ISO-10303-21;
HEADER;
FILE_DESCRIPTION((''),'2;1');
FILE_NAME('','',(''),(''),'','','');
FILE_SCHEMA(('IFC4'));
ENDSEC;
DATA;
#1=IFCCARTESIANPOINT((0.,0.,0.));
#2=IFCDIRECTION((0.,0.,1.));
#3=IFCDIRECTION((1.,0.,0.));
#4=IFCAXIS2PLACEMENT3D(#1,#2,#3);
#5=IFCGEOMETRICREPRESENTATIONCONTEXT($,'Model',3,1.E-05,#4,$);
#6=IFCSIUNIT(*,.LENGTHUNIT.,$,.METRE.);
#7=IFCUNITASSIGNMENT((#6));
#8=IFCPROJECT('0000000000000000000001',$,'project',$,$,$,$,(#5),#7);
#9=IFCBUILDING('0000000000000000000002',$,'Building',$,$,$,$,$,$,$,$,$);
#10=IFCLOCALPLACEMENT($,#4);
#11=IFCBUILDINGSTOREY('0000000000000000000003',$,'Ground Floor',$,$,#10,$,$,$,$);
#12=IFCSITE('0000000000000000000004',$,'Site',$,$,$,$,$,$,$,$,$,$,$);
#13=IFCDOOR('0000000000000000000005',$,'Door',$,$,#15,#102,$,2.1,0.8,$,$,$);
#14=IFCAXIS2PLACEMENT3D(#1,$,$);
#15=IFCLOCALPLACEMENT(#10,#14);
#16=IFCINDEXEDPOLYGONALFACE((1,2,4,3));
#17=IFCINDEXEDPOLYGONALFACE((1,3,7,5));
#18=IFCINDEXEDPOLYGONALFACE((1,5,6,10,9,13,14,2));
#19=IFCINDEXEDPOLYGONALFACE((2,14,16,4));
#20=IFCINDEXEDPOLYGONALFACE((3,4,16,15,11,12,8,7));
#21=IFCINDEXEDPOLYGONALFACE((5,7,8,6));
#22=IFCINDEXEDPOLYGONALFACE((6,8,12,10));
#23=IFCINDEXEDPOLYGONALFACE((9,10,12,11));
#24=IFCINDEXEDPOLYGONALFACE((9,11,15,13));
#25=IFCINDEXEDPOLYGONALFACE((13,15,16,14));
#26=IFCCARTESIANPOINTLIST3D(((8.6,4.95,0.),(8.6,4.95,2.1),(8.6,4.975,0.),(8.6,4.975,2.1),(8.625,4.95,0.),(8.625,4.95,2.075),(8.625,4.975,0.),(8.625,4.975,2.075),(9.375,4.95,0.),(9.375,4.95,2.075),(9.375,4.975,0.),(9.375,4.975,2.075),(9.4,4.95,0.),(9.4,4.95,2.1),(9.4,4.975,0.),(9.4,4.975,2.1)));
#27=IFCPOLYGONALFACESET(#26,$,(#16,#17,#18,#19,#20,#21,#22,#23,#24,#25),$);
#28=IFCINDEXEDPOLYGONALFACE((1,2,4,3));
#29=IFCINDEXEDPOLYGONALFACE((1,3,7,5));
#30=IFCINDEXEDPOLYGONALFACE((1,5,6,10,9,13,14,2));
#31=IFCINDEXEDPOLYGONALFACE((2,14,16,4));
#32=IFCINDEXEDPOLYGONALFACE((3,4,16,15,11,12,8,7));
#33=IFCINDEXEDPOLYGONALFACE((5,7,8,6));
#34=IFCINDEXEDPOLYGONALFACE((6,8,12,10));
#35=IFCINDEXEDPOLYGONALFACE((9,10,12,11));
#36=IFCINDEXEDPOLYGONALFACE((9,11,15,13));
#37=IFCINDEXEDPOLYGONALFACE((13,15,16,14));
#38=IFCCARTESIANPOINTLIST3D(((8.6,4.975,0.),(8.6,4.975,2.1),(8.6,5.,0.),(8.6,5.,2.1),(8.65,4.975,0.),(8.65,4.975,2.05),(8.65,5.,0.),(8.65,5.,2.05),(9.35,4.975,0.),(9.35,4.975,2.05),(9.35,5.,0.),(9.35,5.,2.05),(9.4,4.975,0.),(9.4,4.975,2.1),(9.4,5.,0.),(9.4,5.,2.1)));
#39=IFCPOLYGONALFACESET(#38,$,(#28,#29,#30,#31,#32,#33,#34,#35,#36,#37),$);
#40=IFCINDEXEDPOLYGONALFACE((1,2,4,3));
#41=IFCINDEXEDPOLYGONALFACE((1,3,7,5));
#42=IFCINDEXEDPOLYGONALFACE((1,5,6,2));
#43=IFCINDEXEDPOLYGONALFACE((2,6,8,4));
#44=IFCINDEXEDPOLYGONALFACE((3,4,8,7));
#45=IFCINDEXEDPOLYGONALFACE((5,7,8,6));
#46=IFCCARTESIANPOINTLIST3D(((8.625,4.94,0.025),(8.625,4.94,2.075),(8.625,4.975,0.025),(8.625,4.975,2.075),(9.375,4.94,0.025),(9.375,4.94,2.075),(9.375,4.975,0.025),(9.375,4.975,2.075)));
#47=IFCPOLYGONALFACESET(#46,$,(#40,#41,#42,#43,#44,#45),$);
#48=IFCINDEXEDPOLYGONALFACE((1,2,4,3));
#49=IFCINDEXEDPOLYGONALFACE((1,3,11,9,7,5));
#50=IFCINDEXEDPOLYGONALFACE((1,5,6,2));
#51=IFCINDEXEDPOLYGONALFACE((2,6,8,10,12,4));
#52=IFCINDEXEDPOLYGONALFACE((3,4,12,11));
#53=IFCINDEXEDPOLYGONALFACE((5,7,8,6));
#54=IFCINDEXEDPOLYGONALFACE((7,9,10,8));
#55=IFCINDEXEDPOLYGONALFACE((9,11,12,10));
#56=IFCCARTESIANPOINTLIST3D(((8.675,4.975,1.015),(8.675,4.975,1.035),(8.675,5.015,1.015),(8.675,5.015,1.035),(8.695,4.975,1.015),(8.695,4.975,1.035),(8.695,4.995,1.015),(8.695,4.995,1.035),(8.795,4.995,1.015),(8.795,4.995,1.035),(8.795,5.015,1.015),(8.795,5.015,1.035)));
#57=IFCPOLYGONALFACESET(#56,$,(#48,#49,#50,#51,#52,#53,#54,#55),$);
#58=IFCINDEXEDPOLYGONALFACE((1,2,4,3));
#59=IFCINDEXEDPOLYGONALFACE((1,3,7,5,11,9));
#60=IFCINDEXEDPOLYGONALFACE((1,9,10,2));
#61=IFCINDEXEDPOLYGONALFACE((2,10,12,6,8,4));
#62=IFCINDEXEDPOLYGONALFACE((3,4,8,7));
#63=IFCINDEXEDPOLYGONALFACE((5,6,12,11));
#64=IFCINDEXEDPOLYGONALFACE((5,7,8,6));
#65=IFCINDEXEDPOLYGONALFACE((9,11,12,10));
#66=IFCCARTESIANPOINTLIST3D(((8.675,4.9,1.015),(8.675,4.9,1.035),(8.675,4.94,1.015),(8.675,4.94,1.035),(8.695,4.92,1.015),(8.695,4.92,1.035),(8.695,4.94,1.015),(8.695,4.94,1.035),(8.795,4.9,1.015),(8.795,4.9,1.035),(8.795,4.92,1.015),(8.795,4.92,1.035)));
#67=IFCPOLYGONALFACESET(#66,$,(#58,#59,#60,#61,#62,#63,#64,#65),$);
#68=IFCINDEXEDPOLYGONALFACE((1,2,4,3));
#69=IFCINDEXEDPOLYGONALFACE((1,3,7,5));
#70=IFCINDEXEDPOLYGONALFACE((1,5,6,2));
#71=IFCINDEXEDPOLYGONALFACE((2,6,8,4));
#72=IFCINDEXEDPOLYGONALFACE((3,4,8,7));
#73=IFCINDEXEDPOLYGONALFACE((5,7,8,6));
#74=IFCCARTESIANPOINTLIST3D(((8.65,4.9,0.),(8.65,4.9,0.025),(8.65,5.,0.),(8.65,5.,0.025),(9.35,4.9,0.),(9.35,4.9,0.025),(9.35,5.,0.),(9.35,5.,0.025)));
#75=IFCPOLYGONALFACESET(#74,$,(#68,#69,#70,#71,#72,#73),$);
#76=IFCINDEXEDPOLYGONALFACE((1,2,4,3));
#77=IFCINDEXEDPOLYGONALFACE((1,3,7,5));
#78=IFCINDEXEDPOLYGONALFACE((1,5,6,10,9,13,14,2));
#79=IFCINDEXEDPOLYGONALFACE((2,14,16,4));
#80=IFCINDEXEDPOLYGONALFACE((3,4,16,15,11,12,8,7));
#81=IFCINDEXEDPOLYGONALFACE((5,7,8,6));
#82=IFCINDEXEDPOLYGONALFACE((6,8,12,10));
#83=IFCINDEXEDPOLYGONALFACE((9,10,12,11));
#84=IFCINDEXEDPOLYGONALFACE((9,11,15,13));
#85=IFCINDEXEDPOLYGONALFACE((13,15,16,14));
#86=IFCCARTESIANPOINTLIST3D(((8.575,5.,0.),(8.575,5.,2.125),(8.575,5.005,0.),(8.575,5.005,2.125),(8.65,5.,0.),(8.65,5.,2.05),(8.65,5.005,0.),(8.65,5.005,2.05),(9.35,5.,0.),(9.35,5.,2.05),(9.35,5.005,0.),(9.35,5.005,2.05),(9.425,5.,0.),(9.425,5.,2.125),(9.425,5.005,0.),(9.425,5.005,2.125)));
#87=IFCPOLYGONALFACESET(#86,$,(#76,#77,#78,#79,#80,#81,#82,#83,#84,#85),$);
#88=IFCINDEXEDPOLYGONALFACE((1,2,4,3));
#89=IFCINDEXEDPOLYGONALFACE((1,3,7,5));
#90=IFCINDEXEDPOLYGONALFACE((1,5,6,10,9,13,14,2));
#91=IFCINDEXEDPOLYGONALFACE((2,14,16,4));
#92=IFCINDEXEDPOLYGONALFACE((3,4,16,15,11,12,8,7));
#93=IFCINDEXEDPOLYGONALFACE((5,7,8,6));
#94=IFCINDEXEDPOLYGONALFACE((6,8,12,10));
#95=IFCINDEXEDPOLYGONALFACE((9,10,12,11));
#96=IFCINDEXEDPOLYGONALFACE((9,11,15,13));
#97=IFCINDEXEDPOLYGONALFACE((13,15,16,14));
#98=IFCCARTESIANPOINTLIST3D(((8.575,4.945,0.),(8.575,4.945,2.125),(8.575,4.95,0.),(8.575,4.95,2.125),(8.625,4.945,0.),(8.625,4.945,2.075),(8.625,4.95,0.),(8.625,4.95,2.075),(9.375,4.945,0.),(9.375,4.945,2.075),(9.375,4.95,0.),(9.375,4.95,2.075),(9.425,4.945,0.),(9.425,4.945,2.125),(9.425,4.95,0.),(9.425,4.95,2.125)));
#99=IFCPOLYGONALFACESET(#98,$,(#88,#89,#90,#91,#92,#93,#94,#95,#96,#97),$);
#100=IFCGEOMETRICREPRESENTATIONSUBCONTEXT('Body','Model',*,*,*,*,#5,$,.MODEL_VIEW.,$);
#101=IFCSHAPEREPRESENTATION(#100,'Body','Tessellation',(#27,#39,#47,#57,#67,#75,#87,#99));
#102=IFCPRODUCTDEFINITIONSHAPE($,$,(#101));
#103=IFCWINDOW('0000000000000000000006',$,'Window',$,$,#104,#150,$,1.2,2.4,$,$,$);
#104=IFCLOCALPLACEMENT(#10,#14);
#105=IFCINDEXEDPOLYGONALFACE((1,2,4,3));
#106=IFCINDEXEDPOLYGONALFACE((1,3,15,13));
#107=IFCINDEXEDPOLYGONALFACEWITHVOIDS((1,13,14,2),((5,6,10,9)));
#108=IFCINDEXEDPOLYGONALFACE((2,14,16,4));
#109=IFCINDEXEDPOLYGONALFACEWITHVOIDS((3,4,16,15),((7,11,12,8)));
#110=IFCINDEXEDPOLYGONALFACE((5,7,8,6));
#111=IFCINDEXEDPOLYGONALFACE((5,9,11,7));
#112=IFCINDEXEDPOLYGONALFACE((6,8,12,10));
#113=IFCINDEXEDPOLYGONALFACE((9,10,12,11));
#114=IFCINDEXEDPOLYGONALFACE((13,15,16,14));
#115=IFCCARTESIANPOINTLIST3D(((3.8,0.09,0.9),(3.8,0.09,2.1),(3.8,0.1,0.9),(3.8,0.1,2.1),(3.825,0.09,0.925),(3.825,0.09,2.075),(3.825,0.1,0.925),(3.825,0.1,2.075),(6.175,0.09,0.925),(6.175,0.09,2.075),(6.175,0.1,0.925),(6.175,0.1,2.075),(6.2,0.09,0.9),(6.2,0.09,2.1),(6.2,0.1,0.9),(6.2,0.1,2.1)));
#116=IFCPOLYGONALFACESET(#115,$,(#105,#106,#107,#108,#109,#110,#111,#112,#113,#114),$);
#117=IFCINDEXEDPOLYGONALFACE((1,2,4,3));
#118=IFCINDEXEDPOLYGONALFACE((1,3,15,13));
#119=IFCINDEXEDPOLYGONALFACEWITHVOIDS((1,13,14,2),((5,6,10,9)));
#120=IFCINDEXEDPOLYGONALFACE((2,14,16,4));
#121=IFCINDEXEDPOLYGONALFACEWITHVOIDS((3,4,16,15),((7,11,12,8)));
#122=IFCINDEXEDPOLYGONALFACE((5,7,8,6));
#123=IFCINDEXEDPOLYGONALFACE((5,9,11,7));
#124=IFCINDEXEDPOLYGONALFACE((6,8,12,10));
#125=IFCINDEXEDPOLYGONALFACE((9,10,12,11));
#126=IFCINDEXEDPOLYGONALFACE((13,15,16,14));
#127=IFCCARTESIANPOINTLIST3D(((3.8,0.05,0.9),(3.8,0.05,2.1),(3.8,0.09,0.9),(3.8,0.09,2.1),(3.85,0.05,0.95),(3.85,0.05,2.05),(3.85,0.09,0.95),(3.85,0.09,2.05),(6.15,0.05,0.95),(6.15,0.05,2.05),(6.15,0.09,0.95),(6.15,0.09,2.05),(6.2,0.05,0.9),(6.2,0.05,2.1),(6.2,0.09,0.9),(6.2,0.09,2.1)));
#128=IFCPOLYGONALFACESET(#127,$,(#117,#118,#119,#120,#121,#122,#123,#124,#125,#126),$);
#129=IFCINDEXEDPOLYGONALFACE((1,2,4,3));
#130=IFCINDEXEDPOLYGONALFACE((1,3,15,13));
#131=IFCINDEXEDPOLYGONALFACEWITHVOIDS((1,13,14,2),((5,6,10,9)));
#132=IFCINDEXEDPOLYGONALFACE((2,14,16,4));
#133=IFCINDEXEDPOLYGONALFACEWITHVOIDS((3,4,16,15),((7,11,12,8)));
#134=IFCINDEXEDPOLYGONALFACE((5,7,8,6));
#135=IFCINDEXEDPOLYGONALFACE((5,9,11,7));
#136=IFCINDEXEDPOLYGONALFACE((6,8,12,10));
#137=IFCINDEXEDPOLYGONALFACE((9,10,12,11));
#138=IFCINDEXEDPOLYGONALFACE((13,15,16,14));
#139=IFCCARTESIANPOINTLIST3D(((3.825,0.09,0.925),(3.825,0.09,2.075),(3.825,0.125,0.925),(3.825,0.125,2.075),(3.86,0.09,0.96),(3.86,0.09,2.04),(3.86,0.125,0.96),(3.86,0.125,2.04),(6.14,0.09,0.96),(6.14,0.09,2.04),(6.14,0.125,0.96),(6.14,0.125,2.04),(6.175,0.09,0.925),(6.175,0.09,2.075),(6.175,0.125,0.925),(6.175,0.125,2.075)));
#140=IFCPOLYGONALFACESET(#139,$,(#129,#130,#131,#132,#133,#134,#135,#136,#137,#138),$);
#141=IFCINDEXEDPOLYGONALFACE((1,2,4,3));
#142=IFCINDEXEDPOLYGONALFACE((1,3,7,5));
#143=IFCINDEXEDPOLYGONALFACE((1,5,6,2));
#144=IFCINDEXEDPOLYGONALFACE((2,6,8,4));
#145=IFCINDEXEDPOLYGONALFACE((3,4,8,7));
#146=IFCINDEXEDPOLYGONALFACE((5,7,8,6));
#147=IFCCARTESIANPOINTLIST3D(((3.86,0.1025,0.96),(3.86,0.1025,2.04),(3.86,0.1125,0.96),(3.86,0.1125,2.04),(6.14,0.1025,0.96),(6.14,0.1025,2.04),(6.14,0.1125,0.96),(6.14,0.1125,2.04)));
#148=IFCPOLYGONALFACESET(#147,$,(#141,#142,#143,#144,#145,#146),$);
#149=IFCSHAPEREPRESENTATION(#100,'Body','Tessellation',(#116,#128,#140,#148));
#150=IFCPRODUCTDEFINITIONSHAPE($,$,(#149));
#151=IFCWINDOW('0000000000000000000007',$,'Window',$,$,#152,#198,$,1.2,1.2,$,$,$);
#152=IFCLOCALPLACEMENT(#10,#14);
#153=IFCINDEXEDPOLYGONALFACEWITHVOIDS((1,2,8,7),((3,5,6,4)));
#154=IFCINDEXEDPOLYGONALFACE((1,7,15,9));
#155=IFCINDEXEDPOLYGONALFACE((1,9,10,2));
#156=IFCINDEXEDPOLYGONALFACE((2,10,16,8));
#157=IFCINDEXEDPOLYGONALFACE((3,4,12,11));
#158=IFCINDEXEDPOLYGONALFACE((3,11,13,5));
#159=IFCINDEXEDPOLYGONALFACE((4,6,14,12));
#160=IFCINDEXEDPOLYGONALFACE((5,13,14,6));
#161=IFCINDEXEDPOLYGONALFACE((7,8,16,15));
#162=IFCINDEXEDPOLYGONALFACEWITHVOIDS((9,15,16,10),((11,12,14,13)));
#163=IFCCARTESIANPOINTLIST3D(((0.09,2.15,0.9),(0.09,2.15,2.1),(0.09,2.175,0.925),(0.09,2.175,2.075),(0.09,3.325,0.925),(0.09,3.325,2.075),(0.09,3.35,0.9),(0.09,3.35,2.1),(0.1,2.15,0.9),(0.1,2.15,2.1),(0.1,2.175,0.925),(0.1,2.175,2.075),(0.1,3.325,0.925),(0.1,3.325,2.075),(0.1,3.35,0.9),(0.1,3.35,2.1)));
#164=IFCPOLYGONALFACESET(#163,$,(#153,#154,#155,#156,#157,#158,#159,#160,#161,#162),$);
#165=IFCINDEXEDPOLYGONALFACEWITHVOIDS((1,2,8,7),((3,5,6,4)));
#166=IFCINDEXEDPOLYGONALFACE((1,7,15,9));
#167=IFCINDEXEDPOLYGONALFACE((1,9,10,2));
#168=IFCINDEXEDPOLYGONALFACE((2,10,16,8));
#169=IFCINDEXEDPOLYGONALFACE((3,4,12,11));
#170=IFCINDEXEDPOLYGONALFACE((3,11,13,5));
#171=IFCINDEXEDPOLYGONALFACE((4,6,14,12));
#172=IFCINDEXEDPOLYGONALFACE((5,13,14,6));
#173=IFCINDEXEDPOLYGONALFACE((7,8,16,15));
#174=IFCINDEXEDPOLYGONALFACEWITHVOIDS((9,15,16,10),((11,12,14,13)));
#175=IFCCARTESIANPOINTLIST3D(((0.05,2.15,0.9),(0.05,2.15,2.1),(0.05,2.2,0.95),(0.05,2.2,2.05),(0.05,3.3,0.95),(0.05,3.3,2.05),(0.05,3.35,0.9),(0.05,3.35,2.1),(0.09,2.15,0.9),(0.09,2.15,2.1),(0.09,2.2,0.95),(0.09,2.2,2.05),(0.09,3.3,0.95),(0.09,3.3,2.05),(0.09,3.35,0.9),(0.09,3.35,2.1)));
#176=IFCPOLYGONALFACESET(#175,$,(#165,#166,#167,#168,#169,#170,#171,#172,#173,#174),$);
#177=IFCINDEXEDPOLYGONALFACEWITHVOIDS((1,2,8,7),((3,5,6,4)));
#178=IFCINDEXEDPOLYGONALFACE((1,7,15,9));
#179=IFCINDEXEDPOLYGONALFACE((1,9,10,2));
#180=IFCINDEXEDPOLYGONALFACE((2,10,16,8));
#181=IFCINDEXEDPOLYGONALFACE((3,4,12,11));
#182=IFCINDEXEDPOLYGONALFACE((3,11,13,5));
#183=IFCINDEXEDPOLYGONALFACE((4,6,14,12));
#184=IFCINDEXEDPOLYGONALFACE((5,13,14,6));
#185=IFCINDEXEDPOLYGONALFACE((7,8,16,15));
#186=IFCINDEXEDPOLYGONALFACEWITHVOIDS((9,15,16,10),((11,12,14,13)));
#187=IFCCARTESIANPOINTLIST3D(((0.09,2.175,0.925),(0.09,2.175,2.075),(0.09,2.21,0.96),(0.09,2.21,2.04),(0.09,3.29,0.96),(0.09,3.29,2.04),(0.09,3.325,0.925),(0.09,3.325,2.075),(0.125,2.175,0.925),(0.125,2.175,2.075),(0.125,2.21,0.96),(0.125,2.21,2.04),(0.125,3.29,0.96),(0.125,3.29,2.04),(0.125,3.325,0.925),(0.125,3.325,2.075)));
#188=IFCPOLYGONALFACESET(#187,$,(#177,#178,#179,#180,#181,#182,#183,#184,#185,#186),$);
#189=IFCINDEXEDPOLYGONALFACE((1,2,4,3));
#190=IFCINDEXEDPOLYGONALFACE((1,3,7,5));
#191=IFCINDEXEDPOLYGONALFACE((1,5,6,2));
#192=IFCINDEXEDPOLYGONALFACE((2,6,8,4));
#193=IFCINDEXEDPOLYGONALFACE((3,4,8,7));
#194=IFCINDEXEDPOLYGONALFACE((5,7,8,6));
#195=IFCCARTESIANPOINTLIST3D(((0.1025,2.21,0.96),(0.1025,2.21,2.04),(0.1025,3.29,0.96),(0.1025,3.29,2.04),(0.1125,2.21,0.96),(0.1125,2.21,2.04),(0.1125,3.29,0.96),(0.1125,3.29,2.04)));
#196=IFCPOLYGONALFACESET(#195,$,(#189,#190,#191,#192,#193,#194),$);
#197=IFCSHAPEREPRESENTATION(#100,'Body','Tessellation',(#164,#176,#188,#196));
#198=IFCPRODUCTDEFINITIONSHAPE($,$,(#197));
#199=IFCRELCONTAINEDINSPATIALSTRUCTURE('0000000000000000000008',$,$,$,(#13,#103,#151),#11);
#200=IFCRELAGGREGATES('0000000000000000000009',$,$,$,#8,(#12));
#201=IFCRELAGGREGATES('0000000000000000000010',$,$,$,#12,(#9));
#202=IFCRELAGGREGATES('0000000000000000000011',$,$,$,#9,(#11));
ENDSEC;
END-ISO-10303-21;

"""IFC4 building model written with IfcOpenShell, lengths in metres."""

from ifc_helpers import new_model, si_unit, frame, origin_with_axes, place, context, subcontext, project, spatial, line, indexed_curve, outline, extrude, element, save


model = new_model("IFC4")

# Units and contexts
model_context = context("Model", 3, precision=1e-05, world=origin_with_axes())
body_context = subcontext(model_context, "Body", "Model", "MODEL_VIEW")
ifc_project = project(units=[si_unit("LENGTHUNIT", "METRE")], contexts=[model_context])

# Site, building, storey
site = spatial("IfcSite", under=ifc_project, Name="Site")
building = spatial("IfcBuilding", under=site, Name="Building")
storey_placement = place(None, origin_with_axes())
storey = spatial("IfcBuildingStorey", under=building, at=storey_placement, Name="Ground Floor")

# Door
door_1_placement = place(storey_placement, frame((9.4, 5.0, 0.0), z_axis=(0.0, 0.0, 1.0), x_axis=(-1.0, 0.0, 0.0)))
element("IfcDoor", 1, at=door_1_placement, inside=storey, Name="Door", OverallHeight=2.1, OverallWidth=0.8, context=body_context, shape_type="SweptSolid", body=[
    extrude(outline(indexed_curve([(0.0, 0.0), (0.0, 2.1), (0.8, 2.1), (0.8, 0.0), (0.775, 0.0), (0.775, 2.075), (0.025, 2.075), (0.025, 0.0)], segments=[line(1, 2, 3, 4, 5, 6, 7, 8, 1)])), frame((0.0, 0.025, 0.0), z_axis=(0.0, -1.0, 0.0), x_axis=(1.0, 0.0, 0.0)), (0.0, 0.0, -1.0), 0.025),
    extrude(outline(indexed_curve([(0.0, 0.0), (0.0, 2.1), (0.8, 2.1), (0.8, 0.0), (0.75, 0.0), (0.75, 2.05), (0.05, 2.05), (0.05, 0.0)], segments=[line(1, 2, 3, 4, 5, 6, 7, 8, 1)])), frame((0.0, 0.0, 0.0), z_axis=(0.0, -1.0, 0.0), x_axis=(1.0, 0.0, 0.0)), (0.0, 0.0, -1.0), 0.025),
    extrude(outline(indexed_curve([(0.0, 0.0), (0.75, 0.0), (0.75, 0.035), (0.0, 0.035)], segments=[line(1, 2, 3, 4, 1)])), frame((0.025, 0.025, 0.025), z_axis=(0.0, 0.0, 1.0), x_axis=(1.0, 0.0, 0.0)), (0.0, 0.0, 1.0), 2.05),
    extrude(outline(indexed_curve([(0.0, 0.0), (0.0, -0.04), (-0.12, -0.04), (-0.12, -0.02), (-0.02, -0.02), (-0.02, 0.0)], segments=[line(1, 2, 3, 4, 5, 6, 1)])), frame((0.725, 0.025, 1.015), z_axis=(0.0, 0.0, 1.0), x_axis=(1.0, 0.0, 0.0)), (0.0, 0.0, 1.0), 0.02),
    extrude(outline(indexed_curve([(0.0, 0.0), (0.0, 0.04), (-0.12, 0.04), (-0.12, 0.02), (-0.02, 0.02), (-0.02, 0.0)], segments=[line(1, 2, 3, 4, 5, 6, 1)])), frame((0.725, 0.06, 1.015), z_axis=(0.0, 0.0, 1.0), x_axis=(1.0, 0.0, 0.0)), (0.0, 0.0, 1.0), 0.02),
    extrude(outline(indexed_curve([(0.0, 0.0), (0.7, 0.0), (0.7, 0.1), (0.0, 0.1)], segments=[line(1, 2, 3, 4, 1)])), frame((0.05, 0.0, 0.0), z_axis=(0.0, 0.0, 1.0), x_axis=(1.0, 0.0, 0.0)), (0.0, 0.0, 1.0), 0.025),
    extrude(outline(indexed_curve([(0.0, 0.0), (0.0, 2.125), (0.85, 2.125), (0.85, 0.0), (0.775, 0.0), (0.775, 2.05), (0.075, 2.05), (0.075, 0.0)], segments=[line(1, 2, 3, 4, 5, 6, 7, 8, 1)])), frame((-0.025, -0.005, 0.0), z_axis=(0.0, -1.0, 0.0), x_axis=(1.0, 0.0, 0.0)), (0.0, 0.0, -1.0), 0.005),
    extrude(outline(indexed_curve([(0.0, 0.0), (0.0, 2.125), (0.85, 2.125), (0.85, 0.0), (0.8, 0.0), (0.8, 2.075), (0.05, 2.075), (0.05, 0.0)], segments=[line(1, 2, 3, 4, 5, 6, 7, 8, 1)])), frame((-0.025, 0.05, 0.0), z_axis=(0.0, -1.0, 0.0), x_axis=(1.0, 0.0, 0.0)), (0.0, 0.0, -1.0), 0.005),
])

# Windows
window_1_placement = place(storey_placement, frame((3.8, 0.0, 0.9), z_axis=(0.0, 0.0, 1.0), x_axis=(1.0, 0.0, 0.0)))
element("IfcWindow", 2, at=window_1_placement, inside=storey, Name="Window", OverallHeight=1.2, OverallWidth=2.4, context=body_context, shape_type="SweptSolid", body=[
    extrude(outline(indexed_curve([(0.0, 0.0), (2.4, 0.0), (2.4, 1.2), (0.0, 1.2)], segments=[line(1, 2, 3, 4, 1)]), holes=[indexed_curve([(0.025, 0.025), (2.375, 0.025), (2.375, 1.175), (0.025, 1.175)], segments=[line(1, 2, 3, 4, 1)])]), frame((0.0, 0.09, 0.0), z_axis=(0.0, -1.0, 0.0), x_axis=(1.0, 0.0, 0.0)), (0.0, 0.0, -1.0), 0.01),
    extrude(outline(indexed_curve([(0.0, 0.0), (2.4, 0.0), (2.4, 1.2), (0.0, 1.2)], segments=[line(1, 2, 3, 4, 1)]), holes=[indexed_curve([(0.05, 0.05), (2.35, 0.05), (2.35, 1.15), (0.05, 1.15)], segments=[line(1, 2, 3, 4, 1)])]), frame((0.0, 0.05, 0.0), z_axis=(0.0, -1.0, 0.0), x_axis=(1.0, 0.0, 0.0)), (0.0, 0.0, -1.0), 0.04),
    extrude(outline(indexed_curve([(0.0, 0.0), (2.35, 0.0), (2.35, 1.15), (0.0, 1.15)], segments=[line(1, 2, 3, 4, 1)]), holes=[indexed_curve([(0.035, 0.035), (2.315, 0.035), (2.315, 1.115), (0.035, 1.115)], segments=[line(1, 2, 3, 4, 1)])]), frame((0.025, 0.09, 0.025), z_axis=(0.0, -1.0, 0.0), x_axis=(1.0, 0.0, 0.0)), (0.0, 0.0, -1.0), 0.035),
    extrude(outline(indexed_curve([(0.035, 0.035), (2.315, 0.035), (2.315, 1.115), (0.035, 1.115)], segments=[line(1, 2, 3, 4, 1)])), frame((0.025, 0.1025, 0.025), z_axis=(0.0, -1.0, 0.0), x_axis=(1.0, 0.0, 0.0)), (0.0, 0.0, -1.0), 0.01),
])
for number, where, z_axis, x_axis, name in (
    (3, (0.0, 3.35, 0.9), (0.0, 0.0, 1.0), (0.0, -1.0, 0.0), "Window"),
):
    element("IfcWindow", number, at=place(storey_placement, frame(where, z_axis=z_axis, x_axis=x_axis)), inside=storey, Name=name, OverallHeight=1.2, OverallWidth=1.2, context=body_context, shape_type="SweptSolid", body=[
        extrude(outline(indexed_curve([(0.0, 0.0), (1.2, 0.0), (1.2, 1.2), (0.0, 1.2)], segments=[line(1, 2, 3, 4, 1)]), holes=[indexed_curve([(0.025, 0.025), (1.175, 0.025), (1.175, 1.175), (0.025, 1.175)], segments=[line(1, 2, 3, 4, 1)])]), frame((0.0, 0.09, 0.0), z_axis=(0.0, -1.0, 0.0), x_axis=(1.0, 0.0, 0.0)), (0.0, 0.0, -1.0), 0.01),
        extrude(outline(indexed_curve([(0.0, 0.0), (1.2, 0.0), (1.2, 1.2), (0.0, 1.2)], segments=[line(1, 2, 3, 4, 1)]), holes=[indexed_curve([(0.05, 0.05), (1.15, 0.05), (1.15, 1.15), (0.05, 1.15)], segments=[line(1, 2, 3, 4, 1)])]), frame((0.0, 0.05, 0.0), z_axis=(0.0, -1.0, 0.0), x_axis=(1.0, 0.0, 0.0)), (0.0, 0.0, -1.0), 0.04),
        extrude(outline(indexed_curve([(0.0, 0.0), (1.15, 0.0), (1.15, 1.15), (0.0, 1.15)], segments=[line(1, 2, 3, 4, 1)]), holes=[indexed_curve([(0.035, 0.035), (1.115, 0.035), (1.115, 1.115), (0.035, 1.115)], segments=[line(1, 2, 3, 4, 1)])]), frame((0.025, 0.09, 0.025), z_axis=(0.0, -1.0, 0.0), x_axis=(1.0, 0.0, 0.0)), (0.0, 0.0, -1.0), 0.035),
        extrude(outline(indexed_curve([(0.035, 0.035), (1.115, 0.035), (1.115, 1.115), (0.035, 1.115)], segments=[line(1, 2, 3, 4, 1)])), frame((0.025, 0.1025, 0.025), z_axis=(0.0, -1.0, 0.0), x_axis=(1.0, 0.0, 0.0)), (0.0, 0.0, -1.0), 0.01),
    ])

save(model, "model.ifc")
